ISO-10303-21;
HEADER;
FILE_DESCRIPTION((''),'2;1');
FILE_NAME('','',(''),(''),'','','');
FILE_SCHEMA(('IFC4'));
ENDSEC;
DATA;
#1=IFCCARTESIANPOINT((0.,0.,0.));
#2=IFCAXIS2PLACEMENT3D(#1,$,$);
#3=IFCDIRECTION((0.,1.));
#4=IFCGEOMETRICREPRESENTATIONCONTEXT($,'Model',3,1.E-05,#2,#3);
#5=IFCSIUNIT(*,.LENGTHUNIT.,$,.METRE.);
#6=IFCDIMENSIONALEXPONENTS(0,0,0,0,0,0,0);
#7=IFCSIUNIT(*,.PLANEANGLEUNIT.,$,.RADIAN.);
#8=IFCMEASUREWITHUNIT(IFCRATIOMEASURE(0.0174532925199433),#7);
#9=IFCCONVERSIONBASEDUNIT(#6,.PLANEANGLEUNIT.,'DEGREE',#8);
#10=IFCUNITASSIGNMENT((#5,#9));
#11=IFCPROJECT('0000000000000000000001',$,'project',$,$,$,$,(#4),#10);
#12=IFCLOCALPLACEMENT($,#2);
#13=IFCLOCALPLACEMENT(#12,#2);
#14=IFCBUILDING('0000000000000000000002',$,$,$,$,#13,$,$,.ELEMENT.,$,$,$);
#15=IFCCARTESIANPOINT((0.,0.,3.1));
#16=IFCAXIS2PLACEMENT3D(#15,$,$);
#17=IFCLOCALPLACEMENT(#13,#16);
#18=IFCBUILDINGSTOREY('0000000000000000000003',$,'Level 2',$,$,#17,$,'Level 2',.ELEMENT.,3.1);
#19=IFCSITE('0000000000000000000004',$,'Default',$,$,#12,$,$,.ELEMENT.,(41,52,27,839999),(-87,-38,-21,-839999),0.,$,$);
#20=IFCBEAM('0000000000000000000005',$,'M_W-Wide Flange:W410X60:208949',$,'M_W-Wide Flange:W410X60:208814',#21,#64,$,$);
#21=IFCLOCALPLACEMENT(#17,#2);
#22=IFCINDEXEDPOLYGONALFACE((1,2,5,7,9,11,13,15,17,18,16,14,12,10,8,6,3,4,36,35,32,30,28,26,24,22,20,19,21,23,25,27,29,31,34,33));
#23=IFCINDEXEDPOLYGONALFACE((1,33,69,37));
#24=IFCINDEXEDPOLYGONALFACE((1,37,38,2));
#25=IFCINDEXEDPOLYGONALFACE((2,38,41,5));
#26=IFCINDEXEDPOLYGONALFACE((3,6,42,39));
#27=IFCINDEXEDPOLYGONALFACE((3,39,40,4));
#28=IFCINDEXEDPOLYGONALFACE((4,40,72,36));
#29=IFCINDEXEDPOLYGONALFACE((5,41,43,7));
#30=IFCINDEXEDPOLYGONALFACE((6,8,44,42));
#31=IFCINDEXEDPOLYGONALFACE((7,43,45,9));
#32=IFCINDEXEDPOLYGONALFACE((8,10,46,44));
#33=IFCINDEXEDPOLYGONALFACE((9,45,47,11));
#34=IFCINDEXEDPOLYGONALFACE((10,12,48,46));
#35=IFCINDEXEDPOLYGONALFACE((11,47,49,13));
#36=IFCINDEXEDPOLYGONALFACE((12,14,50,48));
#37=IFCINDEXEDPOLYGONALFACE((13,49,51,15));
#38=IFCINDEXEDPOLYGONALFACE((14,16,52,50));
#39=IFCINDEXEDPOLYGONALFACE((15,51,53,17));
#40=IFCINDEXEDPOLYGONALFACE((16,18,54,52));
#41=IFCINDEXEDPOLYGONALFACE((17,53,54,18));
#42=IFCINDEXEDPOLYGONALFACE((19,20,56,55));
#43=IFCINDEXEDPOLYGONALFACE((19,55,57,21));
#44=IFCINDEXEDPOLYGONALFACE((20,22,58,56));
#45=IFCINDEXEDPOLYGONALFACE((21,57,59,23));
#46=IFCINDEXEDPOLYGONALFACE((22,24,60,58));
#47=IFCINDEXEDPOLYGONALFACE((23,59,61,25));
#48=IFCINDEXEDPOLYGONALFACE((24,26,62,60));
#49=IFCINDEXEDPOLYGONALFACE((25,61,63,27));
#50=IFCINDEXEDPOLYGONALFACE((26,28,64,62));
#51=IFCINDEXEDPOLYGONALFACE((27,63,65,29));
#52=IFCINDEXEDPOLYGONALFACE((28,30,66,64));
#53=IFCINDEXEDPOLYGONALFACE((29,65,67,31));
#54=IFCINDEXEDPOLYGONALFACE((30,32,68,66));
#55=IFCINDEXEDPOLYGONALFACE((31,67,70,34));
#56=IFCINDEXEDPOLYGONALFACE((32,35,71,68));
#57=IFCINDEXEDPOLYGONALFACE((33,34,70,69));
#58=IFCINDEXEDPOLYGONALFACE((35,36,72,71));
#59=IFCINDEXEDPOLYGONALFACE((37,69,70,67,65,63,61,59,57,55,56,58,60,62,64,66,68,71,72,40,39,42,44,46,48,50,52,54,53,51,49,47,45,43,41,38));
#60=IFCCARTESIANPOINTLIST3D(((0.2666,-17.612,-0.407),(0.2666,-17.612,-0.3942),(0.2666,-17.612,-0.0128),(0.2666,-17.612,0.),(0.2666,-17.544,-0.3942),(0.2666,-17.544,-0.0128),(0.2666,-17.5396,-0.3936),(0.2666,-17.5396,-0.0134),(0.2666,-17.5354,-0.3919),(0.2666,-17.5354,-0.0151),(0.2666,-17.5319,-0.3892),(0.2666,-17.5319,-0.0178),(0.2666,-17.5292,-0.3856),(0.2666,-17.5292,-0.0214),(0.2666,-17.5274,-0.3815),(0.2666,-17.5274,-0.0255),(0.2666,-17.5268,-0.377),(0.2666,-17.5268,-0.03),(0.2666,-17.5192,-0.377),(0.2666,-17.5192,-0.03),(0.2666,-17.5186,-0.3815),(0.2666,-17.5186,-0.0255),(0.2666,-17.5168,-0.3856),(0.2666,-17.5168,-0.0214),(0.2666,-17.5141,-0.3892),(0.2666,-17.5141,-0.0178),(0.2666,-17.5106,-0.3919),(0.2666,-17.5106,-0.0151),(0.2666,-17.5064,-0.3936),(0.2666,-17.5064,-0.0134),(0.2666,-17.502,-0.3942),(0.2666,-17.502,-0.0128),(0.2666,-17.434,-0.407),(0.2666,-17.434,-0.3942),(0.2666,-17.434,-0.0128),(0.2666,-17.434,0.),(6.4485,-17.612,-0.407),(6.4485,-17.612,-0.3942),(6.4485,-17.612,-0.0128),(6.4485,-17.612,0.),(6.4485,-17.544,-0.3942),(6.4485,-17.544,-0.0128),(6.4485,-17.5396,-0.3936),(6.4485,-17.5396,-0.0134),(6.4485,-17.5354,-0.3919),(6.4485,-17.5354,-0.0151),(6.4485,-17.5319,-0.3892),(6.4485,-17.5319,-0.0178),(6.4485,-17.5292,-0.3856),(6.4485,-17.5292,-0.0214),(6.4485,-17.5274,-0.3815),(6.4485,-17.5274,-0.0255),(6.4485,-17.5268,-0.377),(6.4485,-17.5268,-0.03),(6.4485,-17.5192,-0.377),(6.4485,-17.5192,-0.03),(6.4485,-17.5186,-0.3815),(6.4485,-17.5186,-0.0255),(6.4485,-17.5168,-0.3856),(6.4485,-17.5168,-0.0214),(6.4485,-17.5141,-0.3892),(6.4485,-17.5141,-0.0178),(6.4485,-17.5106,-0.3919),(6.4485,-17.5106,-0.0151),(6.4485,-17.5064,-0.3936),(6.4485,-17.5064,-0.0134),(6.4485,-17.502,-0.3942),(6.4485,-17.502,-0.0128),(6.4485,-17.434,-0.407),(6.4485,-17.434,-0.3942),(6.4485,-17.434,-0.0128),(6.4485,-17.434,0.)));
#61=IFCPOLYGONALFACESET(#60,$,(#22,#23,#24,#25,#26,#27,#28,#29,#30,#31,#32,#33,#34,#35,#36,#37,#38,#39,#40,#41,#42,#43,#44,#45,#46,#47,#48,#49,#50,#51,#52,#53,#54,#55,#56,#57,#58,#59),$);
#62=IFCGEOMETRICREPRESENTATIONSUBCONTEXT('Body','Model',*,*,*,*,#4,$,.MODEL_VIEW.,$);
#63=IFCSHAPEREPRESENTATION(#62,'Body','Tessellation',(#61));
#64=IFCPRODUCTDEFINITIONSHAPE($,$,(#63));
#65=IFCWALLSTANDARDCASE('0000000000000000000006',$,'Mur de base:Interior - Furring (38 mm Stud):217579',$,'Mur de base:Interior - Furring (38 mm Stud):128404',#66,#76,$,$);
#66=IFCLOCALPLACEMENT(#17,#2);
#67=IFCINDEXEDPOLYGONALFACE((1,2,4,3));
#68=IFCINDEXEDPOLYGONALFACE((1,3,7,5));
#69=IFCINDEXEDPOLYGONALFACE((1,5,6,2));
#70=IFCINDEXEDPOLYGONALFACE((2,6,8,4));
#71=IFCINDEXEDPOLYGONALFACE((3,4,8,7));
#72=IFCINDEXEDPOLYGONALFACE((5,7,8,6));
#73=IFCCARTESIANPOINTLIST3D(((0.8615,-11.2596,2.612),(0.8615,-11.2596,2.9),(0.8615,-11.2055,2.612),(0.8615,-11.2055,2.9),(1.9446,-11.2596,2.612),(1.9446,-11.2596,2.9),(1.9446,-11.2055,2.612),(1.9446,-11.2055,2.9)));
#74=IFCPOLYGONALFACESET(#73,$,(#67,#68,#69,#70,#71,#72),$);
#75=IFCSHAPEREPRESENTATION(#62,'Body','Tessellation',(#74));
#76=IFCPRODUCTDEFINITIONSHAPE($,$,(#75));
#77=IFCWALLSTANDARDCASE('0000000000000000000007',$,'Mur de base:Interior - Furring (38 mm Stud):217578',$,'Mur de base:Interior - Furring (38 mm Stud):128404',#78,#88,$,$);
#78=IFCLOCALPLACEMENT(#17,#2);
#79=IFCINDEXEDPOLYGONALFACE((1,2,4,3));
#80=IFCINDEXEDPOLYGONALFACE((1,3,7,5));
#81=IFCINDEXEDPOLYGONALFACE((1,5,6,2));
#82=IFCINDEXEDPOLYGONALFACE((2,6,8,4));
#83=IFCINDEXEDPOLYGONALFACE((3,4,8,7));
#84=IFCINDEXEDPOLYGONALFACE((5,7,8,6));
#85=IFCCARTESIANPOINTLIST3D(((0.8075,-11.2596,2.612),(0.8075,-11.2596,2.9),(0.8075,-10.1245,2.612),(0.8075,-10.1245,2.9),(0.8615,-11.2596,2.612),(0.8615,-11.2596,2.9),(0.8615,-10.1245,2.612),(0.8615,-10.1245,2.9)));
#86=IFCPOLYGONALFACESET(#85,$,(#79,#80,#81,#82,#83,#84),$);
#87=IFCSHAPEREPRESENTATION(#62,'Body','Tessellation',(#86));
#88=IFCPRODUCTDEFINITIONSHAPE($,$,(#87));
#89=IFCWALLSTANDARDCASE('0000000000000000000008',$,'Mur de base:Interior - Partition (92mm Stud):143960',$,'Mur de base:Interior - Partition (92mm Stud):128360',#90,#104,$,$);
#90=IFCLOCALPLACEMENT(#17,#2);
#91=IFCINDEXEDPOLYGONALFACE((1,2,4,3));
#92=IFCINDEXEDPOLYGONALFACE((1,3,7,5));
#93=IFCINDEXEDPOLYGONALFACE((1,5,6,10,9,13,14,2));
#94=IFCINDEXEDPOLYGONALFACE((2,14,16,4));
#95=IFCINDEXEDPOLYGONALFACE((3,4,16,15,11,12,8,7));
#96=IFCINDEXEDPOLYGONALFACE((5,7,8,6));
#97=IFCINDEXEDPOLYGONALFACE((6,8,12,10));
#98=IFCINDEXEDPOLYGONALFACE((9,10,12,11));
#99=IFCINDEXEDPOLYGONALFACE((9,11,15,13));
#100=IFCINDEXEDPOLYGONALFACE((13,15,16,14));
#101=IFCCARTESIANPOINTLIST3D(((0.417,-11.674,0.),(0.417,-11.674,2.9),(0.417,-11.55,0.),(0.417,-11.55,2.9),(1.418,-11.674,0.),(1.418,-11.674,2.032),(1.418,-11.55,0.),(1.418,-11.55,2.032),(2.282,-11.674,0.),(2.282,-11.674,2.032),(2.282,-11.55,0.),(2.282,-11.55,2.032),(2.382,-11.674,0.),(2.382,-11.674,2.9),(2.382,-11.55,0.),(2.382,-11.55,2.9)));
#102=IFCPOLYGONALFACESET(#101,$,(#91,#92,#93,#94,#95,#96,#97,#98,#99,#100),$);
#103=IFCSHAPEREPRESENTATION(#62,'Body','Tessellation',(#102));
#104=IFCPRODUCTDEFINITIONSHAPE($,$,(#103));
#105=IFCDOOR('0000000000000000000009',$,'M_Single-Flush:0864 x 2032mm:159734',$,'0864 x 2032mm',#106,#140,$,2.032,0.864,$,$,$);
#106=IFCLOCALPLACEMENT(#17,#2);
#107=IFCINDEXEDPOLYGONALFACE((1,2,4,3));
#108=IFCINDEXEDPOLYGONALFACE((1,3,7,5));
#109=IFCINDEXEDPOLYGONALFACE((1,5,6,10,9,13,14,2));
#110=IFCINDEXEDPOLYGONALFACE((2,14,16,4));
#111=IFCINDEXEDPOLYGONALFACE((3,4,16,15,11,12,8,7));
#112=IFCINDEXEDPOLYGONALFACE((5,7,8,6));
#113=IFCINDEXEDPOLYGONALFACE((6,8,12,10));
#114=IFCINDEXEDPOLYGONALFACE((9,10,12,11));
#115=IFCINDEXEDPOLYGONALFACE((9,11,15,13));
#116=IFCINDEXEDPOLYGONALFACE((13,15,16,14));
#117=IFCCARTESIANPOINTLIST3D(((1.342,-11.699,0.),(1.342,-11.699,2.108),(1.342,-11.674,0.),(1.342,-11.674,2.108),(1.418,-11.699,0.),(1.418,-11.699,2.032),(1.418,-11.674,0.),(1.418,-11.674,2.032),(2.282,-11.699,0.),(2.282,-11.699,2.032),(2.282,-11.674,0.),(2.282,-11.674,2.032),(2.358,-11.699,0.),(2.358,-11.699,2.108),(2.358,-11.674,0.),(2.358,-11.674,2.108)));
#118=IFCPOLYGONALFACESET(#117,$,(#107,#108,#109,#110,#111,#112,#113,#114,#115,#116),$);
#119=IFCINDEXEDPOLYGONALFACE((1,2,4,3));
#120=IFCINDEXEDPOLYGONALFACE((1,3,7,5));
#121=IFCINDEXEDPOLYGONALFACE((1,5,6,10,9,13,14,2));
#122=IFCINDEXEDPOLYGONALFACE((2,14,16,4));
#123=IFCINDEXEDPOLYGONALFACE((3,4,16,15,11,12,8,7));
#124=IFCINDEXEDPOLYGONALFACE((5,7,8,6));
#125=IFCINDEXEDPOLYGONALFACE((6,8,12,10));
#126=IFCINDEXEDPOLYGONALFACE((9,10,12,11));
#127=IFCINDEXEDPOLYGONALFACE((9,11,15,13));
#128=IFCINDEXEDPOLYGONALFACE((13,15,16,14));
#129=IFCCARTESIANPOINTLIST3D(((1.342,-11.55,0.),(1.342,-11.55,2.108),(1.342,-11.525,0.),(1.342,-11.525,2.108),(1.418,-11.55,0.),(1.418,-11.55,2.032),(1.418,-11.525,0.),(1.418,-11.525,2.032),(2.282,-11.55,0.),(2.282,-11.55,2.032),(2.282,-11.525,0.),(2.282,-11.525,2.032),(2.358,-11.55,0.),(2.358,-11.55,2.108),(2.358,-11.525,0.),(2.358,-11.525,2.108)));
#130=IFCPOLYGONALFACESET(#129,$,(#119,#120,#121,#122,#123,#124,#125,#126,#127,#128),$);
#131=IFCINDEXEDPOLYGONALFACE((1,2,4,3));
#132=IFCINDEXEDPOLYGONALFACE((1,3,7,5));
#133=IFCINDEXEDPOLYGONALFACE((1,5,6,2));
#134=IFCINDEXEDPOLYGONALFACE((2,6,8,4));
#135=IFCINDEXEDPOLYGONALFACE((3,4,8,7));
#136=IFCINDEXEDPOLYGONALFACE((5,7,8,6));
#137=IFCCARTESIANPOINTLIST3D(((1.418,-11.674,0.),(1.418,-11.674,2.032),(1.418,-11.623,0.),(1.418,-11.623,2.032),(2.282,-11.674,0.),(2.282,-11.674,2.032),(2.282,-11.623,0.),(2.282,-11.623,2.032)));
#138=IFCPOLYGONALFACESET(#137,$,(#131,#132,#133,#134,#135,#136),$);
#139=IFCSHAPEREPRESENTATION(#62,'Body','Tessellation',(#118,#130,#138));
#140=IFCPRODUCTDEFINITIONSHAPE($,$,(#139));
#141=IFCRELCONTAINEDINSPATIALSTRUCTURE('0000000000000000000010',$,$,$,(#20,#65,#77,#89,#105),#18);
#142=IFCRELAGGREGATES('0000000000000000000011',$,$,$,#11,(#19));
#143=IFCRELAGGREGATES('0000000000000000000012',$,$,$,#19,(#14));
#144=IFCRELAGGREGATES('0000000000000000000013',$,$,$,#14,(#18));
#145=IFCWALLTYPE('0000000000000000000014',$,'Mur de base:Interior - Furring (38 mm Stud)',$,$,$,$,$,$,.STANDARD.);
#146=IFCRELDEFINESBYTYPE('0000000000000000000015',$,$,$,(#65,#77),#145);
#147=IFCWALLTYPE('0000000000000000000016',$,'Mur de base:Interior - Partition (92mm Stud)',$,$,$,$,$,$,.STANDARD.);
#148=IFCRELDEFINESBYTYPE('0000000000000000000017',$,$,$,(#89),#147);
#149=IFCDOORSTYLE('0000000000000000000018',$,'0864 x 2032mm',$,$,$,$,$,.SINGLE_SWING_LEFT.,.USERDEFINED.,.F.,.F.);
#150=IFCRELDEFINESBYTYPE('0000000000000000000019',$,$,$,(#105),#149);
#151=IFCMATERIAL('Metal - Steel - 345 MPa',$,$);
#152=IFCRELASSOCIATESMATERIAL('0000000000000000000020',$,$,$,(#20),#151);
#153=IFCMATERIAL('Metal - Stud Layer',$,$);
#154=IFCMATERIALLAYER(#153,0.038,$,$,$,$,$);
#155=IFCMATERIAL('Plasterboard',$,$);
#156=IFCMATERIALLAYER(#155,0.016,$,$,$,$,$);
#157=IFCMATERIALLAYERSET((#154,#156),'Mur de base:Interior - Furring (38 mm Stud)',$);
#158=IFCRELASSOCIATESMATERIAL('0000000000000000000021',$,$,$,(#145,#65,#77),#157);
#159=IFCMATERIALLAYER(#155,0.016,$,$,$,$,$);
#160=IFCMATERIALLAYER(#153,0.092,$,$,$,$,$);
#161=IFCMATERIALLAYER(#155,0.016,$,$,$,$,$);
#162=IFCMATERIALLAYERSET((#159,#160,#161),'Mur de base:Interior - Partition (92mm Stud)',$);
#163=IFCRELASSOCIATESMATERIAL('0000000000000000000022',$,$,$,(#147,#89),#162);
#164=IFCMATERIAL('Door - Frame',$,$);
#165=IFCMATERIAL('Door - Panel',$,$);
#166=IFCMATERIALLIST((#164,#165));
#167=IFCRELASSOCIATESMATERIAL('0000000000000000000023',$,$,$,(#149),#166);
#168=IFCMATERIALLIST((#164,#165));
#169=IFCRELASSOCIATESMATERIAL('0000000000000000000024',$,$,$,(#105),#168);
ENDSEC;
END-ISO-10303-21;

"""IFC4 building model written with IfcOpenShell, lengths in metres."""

from ifc_helpers import new_model, entity, si_unit, converted_unit, direction, frame, frame_2d, origin, place, context, subcontext, project, spatial, polyline, rectangle, i_section, outline, extrude, source, transform, mapped, material, material_list, layer, layer_set, layer_usage, type_object, type_shapes, element, fill, save


model = new_model("IFC4")

# Units and contexts
model_context = context("Model", 3, precision=1e-05, world=origin(), true_north=direction((0.0, 1.0)))
body_context = subcontext(model_context, "Body", "Model", "MODEL_VIEW")
ifc_project = project(units=[si_unit("LENGTHUNIT", "METRE"), converted_unit("PLANEANGLEUNIT", "DEGREE", entity("IfcRatioMeasure", 0.0174532925199433), si_unit("PLANEANGLEUNIT", "RADIAN"), dimensions=[0, 0, 0, 0, 0, 0, 0])], contexts=[model_context])

# Site, building, storey
site_placement = place(None, origin())
site = spatial("IfcSite", under=ifc_project, at=site_placement, Name="Default", CompositionType="ELEMENT", RefLatitude=(41, 52, 27, 839999), RefLongitude=(-87, -38, -21, -839999), RefElevation=0.0)
building_placement = place(site_placement, origin())
building = spatial("IfcBuilding", under=site, at=building_placement, CompositionType="ELEMENT")
storey_placement = place(building_placement, frame((0.0, 0.0, 3.1)))
storey = spatial("IfcBuildingStorey", under=building, at=storey_placement, Name="Level 2", LongName="Level 2", CompositionType="ELEMENT", Elevation=3.1)

# Beam
ifc_material_1 = material(Name="Metal - Steel - 345 MPa")
beam_placement = place(storey_placement, frame((0.2666, -17.523, 0.0)))
element("IfcBeam", 1, at=beam_placement, inside=storey, material=ifc_material_1, Name="M_W-Wide Flange:W410X60:208949", ObjectType="M_W-Wide Flange:W410X60:208814", context=body_context, shape_type="SweptSolid", body=[
    extrude(i_section(OverallWidth=0.178, OverallDepth=0.407, WebThickness=0.0077, FlangeThickness=0.0128, FilletRadius=0.0172, at=frame_2d((0.0, 0.0), x_axis=(0.0, 1.0))), frame((0.0, 0.0, -0.2035), z_axis=(1.0, 0.0, 0.0), x_axis=(0.0, 0.0, -1.0)), (0.0, 0.0, 1.0), 6.1819),
])

# Walls
ifc_material_2 = material(Name="Metal - Stud Layer")
ifc_layer_1 = layer(ifc_material_2, 0.038)
ifc_material_3 = material(Name="Plasterboard")
ifc_layer_2 = layer(ifc_material_3, 0.016)
ifc_layer_set_1 = layer_set([ifc_layer_1, ifc_layer_2], Name="Mur de base:Interior - Furring (38 mm Stud)")
ifc_layer_usage_1 = layer_usage(ifc_layer_set_1, "AXIS2", "NEGATIVE", 0.027)
wall_type_1 = type_object("IfcWallType", Name="Mur de base:Interior - Furring (38 mm Stud)", PredefinedType="STANDARD", material=ifc_layer_set_1)
wall_1_placement = place(storey_placement, frame((1.9446, -11.2325, 2.612), z_axis=(0.0, 0.0, 1.0), x_axis=(-1.0, 0.0, 0.0)))
element("IfcWallStandardCase", 2, at=wall_1_placement, inside=storey, type_object=wall_type_1, material=ifc_layer_usage_1, Name="Mur de base:Interior - Furring (38 mm Stud):217579", ObjectType="Mur de base:Interior - Furring (38 mm Stud):128404", context=body_context, shape_type="SweptSolid", body=[
    extrude(rectangle(XDim=1.0831, YDim=0.054, at=frame_2d((0.5415, 0.0), x_axis=(-1.0, 0.0))), origin(), (0.0, 0.0, 1.0), 0.288),
])
ifc_layer_usage_2 = layer_usage(ifc_layer_set_1, "AXIS2", "NEGATIVE", 0.027)
wall_2_placement = place(storey_placement, frame((0.8345, -11.2596, 2.612), z_axis=(0.0, 0.0, 1.0), x_axis=(0.0, 1.0, 0.0)))
element("IfcWallStandardCase", 3, at=wall_2_placement, inside=storey, type_object=wall_type_1, material=ifc_layer_usage_2, Name="Mur de base:Interior - Furring (38 mm Stud):217578", ObjectType="Mur de base:Interior - Furring (38 mm Stud):128404", context=body_context, shape_type="SweptSolid", body=[
    extrude(rectangle(XDim=1.1351, YDim=0.054, at=frame_2d((0.5675, 0.0), x_axis=(-1.0, 0.0))), origin(), (0.0, 0.0, 1.0), 0.288),
])

# Wall, opening, door
ifc_layer_3 = layer(ifc_material_3, 0.016)
ifc_layer_4 = layer(ifc_material_2, 0.092)
ifc_layer_5 = layer(ifc_material_3, 0.016)
ifc_layer_set_2 = layer_set([ifc_layer_3, ifc_layer_4, ifc_layer_5], Name="Mur de base:Interior - Partition (92mm Stud)")
ifc_layer_usage_3 = layer_usage(ifc_layer_set_2, "AXIS2", "NEGATIVE", 0.062)
wall_type_2 = type_object("IfcWallType", Name="Mur de base:Interior - Partition (92mm Stud)", PredefinedType="STANDARD", material=ifc_layer_set_2)
wall_3_placement = place(storey_placement, frame((2.382, -11.612, 0.0), z_axis=(0.0, 0.0, 1.0), x_axis=(-1.0, 0.0, 0.0)))
wall_3 = element("IfcWallStandardCase", 4, at=wall_3_placement, inside=storey, type_object=wall_type_2, material=ifc_layer_usage_3, Name="Mur de base:Interior - Partition (92mm Stud):143960", ObjectType="Mur de base:Interior - Partition (92mm Stud):128360", context=body_context, shape_type="SweptSolid", body=[
    extrude(rectangle(XDim=1.965, YDim=0.124, at=frame_2d((0.9825, 0.0), x_axis=(-1.0, 0.0))), origin(), (0.0, 0.0, 1.0), 2.9),
])
opening_1_placement = place(wall_3_placement, frame((0.1, -0.062, 0.0)))
opening_1 = element("IfcOpeningElement", 5, at=opening_1_placement, cuts=wall_3, ObjectType="Opening", context=body_context, shape_type="SweptSolid", body=[
    extrude(rectangle(XDim=0.864, YDim=2.032, at=frame_2d((1.016, 0.432), x_axis=(0.0, -1.0))), frame((0.0, 0.0, 0.0), z_axis=(0.0, 1.0, 0.0), x_axis=(0.0, 0.0, 1.0)), (0.0, 0.0, 1.0), 0.124),
])
ifc_material_4 = material(Name="Door - Frame")
ifc_material_5 = material(Name="Door - Panel")
ifc_material_list_1 = material_list([ifc_material_4, ifc_material_5])
ifc_material_list_2 = material_list([ifc_material_4, ifc_material_5])
door_style = type_object("IfcDoorStyle", Name="0864 x 2032mm", ConstructionType="USERDEFINED", OperationType="SINGLE_SWING_LEFT", ParameterTakesPrecedence=False, Sizeable=False, material=ifc_material_list_2)
shared_shape_1 = source(origin(), body_context, "Body", "SweptSolid", [
    extrude(outline(polyline([(-0.508, -1.073), (0.508, -1.073), (0.508, 1.035), (0.432, 1.035), (0.432, -0.997), (-0.432, -0.997), (-0.432, 1.035), (-0.508, 1.035), (-0.508, -1.073)])), frame((0.432, 0.149, 1.035), z_axis=(0.0, -1.0, 0.0), x_axis=(-1.0, 0.0, 0.0)), (0.0, 0.0, 1.0), 0.025),
    extrude(outline(polyline([(-1.073, -0.508), (1.035, -0.508), (1.035, -0.432), (-0.997, -0.432), (-0.997, 0.432), (1.035, 0.432), (1.035, 0.508), (-1.073, 0.508), (-1.073, -0.508)])), frame((0.432, 0.0, 1.035), z_axis=(0.0, -1.0, 0.0), x_axis=(0.0, 0.0, -1.0)), (0.0, 0.0, 1.0), 0.025),
    extrude(rectangle(XDim=0.864, YDim=0.051, at=frame_2d((0.0, 0.0), x_axis=(1.0, 0.0))), frame((0.432, 0.0985, 0.0)), (0.0, 0.0, 1.0), 2.032),
])
type_shapes(door_style, [shared_shape_1])
door_placement = place(opening_1_placement, origin())
door = element("IfcDoor", 6, at=door_placement, inside=storey, type_object=door_style, material=ifc_material_list_1, Name="M_Single-Flush:0864 x 2032mm:159734", ObjectType="0864 x 2032mm", OverallHeight=2.032, OverallWidth=0.864, context=body_context, shape_type="MappedRepresentation", body=[
    mapped(shared_shape_1, transform((0.0, 0.0, 0.0), scale=1.0)),
])
fill(opening_1, door)

save(model, "model.ifc")
